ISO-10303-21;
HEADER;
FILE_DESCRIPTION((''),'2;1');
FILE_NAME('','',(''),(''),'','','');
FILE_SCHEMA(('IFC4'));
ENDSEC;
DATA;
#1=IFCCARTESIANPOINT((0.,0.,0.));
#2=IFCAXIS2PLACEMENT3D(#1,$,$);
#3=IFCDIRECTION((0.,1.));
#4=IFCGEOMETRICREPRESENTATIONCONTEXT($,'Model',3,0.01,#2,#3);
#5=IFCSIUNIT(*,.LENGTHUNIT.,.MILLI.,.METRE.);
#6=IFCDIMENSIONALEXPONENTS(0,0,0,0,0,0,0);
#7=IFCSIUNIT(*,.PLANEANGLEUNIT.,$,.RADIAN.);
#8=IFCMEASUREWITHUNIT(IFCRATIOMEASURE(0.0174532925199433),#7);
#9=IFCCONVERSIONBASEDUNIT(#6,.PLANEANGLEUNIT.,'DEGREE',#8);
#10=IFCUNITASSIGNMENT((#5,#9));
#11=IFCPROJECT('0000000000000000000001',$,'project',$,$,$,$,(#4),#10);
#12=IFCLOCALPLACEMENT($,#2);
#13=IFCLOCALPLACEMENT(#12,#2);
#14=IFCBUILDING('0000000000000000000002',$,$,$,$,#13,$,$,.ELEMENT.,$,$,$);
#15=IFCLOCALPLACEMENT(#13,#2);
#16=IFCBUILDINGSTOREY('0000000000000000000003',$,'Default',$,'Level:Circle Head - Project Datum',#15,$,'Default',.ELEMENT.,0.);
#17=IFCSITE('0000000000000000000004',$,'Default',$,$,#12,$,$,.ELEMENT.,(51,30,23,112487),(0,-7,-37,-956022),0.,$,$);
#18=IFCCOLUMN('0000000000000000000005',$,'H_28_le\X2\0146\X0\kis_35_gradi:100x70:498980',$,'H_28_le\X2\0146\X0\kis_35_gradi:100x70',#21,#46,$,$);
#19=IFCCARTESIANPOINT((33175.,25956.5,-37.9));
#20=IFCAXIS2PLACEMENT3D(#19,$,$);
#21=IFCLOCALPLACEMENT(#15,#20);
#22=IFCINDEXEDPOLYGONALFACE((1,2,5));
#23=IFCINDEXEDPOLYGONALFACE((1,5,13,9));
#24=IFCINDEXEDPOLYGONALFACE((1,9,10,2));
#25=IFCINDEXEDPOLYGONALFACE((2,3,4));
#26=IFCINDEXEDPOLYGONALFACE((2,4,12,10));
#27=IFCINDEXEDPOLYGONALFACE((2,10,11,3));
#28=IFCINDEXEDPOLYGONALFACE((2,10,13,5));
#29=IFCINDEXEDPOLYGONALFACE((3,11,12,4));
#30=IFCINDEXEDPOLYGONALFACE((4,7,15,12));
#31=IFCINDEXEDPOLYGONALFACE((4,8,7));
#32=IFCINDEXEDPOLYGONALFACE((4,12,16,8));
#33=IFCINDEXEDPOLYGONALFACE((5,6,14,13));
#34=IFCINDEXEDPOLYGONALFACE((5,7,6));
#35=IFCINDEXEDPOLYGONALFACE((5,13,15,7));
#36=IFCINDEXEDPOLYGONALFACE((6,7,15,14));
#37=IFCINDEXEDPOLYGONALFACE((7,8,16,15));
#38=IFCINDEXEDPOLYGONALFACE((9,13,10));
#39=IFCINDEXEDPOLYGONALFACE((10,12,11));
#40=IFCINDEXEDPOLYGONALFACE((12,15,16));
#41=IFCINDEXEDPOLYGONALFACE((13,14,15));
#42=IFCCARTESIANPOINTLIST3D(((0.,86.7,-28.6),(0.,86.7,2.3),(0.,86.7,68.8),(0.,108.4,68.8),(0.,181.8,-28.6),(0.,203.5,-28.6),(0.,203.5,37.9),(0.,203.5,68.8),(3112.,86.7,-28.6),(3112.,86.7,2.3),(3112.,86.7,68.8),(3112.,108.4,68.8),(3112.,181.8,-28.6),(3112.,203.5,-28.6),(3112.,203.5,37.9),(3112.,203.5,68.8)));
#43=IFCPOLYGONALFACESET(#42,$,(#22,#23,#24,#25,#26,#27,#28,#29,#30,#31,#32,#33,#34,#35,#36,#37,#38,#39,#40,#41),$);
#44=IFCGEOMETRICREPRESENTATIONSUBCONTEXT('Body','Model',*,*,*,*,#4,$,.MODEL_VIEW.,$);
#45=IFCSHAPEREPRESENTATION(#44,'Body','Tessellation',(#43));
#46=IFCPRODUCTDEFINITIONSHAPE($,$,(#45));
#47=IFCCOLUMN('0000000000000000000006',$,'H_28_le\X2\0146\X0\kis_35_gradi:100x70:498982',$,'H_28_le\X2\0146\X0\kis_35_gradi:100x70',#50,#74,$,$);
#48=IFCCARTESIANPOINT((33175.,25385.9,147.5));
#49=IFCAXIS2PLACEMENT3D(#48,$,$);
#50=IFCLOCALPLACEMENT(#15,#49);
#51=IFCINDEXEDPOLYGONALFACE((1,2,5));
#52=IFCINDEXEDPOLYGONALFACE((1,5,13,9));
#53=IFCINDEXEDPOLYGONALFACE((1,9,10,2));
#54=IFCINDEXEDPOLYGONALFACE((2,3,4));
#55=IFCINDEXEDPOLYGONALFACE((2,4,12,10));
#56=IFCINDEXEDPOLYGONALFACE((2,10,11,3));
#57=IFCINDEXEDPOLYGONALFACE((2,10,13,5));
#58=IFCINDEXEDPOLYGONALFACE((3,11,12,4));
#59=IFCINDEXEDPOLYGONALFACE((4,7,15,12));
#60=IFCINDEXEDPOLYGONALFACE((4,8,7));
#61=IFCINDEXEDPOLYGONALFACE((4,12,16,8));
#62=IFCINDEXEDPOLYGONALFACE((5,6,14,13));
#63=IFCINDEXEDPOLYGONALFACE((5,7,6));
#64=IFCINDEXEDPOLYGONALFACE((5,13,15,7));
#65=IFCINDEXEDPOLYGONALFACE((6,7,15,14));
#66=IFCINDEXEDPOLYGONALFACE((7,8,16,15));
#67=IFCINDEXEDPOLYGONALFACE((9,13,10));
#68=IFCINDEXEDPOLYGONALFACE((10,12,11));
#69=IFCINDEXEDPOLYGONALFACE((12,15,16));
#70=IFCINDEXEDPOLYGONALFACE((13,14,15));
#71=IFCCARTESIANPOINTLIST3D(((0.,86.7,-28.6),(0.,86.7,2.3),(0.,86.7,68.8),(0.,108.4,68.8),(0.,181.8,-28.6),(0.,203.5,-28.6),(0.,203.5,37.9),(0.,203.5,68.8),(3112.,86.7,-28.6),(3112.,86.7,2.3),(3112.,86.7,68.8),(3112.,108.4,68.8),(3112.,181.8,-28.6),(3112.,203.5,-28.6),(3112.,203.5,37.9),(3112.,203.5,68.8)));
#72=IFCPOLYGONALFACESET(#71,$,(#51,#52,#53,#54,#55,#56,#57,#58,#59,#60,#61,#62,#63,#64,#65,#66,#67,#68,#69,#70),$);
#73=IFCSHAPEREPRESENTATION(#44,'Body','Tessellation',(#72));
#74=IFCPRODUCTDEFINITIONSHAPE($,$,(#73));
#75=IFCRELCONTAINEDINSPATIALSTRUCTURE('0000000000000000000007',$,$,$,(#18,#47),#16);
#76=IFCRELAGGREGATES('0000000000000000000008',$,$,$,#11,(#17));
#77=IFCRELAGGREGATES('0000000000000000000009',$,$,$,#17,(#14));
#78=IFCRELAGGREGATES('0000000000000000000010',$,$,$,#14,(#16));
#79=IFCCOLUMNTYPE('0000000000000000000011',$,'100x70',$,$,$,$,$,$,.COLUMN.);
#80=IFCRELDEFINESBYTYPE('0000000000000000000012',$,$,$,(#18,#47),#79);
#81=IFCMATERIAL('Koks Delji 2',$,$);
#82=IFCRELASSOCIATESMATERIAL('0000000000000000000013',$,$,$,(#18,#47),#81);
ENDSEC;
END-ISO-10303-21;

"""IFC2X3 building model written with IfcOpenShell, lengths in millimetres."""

from ifc_helpers import new_model, entity, si_unit, converted_unit, direction, frame, frame_2d, origin, origin_2d_with_axis, place, context, subcontext, project, spatial, rectangle, extrude, boolean, source, transform, mapped, material, type_object, type_shapes, element, save


model = new_model("IFC2X3")

# Units and contexts
model_context = context("Model", 3, precision=0.01, world=origin(), true_north=direction((0.0, 1.0)))
body_context = subcontext(model_context, "Body", "Model", "MODEL_VIEW")
ifc_project = project(units=[si_unit("LENGTHUNIT", "METRE", prefix="MILLI"), converted_unit("PLANEANGLEUNIT", "DEGREE", entity("IfcRatioMeasure", 0.0174532925199433), si_unit("PLANEANGLEUNIT", "RADIAN"), dimensions=[0, 0, 0, 0, 0, 0, 0])], contexts=[model_context])

# Site, building, storey
site_placement = place(None, origin())
site = spatial("IfcSite", under=ifc_project, at=site_placement, Name="Default", CompositionType="ELEMENT", RefLatitude=(51, 30, 23, 112487), RefLongitude=(0, -7, -37, -956022), RefElevation=0.0)
building_placement = place(site_placement, origin())
building = spatial("IfcBuilding", under=site, at=building_placement, CompositionType="ELEMENT")
storey_placement = place(building_placement, origin())
storey = spatial("IfcBuildingStorey", under=building, at=storey_placement, Name="Default", ObjectType="Level:Circle Head - Project Datum", LongName="Default", CompositionType="ELEMENT", Elevation=0.0)

# Columns
ifc_material_1 = material(Name="Koks Delji 2")
column_type = type_object("IfcColumnType", Name="100x70", PredefinedType="COLUMN")
shared_shape_1 = source(origin(), body_context, "Body", "CSG", [
    boolean("DIFFERENCE", extrude(rectangle(XDim=3112.0, YDim=116.7, at=origin_2d_with_axis()), frame((1556.0, 145.1, -28.6)), (0.0, 0.0, 1.0), 97.5), extrude(rectangle(XDim=70.0, YDim=100.0, at=frame_2d((0.0, 0.0), x_axis=(0.0, 1.0))), frame((3112.0, 145.1, 20.1), z_axis=(1.0, 0.0, 0.0), x_axis=(0.0, 0.951057, -0.309017)), (0.0, 0.0, -1.0), 3112.0)),
])
type_shapes(column_type, [shared_shape_1])
for number, where, name in (
    (1, (33175.0, 25956.5, -37.9), "H_28_leņkis_35_gradi:100x70:498980"),
    (2, (33175.0, 25385.9, 147.5), "H_28_leņkis_35_gradi:100x70:498982"),
):
    element("IfcColumn", number, at=place(storey_placement, frame(where)), inside=storey, type_object=column_type, material=ifc_material_1, Name=name, ObjectType="H_28_leņkis_35_gradi:100x70", context=body_context, shape_type="MappedRepresentation", body=[
        mapped(shared_shape_1, transform((0.0, 0.0, 0.0), scale=1.0)),
    ])

save(model, "model.ifc")
